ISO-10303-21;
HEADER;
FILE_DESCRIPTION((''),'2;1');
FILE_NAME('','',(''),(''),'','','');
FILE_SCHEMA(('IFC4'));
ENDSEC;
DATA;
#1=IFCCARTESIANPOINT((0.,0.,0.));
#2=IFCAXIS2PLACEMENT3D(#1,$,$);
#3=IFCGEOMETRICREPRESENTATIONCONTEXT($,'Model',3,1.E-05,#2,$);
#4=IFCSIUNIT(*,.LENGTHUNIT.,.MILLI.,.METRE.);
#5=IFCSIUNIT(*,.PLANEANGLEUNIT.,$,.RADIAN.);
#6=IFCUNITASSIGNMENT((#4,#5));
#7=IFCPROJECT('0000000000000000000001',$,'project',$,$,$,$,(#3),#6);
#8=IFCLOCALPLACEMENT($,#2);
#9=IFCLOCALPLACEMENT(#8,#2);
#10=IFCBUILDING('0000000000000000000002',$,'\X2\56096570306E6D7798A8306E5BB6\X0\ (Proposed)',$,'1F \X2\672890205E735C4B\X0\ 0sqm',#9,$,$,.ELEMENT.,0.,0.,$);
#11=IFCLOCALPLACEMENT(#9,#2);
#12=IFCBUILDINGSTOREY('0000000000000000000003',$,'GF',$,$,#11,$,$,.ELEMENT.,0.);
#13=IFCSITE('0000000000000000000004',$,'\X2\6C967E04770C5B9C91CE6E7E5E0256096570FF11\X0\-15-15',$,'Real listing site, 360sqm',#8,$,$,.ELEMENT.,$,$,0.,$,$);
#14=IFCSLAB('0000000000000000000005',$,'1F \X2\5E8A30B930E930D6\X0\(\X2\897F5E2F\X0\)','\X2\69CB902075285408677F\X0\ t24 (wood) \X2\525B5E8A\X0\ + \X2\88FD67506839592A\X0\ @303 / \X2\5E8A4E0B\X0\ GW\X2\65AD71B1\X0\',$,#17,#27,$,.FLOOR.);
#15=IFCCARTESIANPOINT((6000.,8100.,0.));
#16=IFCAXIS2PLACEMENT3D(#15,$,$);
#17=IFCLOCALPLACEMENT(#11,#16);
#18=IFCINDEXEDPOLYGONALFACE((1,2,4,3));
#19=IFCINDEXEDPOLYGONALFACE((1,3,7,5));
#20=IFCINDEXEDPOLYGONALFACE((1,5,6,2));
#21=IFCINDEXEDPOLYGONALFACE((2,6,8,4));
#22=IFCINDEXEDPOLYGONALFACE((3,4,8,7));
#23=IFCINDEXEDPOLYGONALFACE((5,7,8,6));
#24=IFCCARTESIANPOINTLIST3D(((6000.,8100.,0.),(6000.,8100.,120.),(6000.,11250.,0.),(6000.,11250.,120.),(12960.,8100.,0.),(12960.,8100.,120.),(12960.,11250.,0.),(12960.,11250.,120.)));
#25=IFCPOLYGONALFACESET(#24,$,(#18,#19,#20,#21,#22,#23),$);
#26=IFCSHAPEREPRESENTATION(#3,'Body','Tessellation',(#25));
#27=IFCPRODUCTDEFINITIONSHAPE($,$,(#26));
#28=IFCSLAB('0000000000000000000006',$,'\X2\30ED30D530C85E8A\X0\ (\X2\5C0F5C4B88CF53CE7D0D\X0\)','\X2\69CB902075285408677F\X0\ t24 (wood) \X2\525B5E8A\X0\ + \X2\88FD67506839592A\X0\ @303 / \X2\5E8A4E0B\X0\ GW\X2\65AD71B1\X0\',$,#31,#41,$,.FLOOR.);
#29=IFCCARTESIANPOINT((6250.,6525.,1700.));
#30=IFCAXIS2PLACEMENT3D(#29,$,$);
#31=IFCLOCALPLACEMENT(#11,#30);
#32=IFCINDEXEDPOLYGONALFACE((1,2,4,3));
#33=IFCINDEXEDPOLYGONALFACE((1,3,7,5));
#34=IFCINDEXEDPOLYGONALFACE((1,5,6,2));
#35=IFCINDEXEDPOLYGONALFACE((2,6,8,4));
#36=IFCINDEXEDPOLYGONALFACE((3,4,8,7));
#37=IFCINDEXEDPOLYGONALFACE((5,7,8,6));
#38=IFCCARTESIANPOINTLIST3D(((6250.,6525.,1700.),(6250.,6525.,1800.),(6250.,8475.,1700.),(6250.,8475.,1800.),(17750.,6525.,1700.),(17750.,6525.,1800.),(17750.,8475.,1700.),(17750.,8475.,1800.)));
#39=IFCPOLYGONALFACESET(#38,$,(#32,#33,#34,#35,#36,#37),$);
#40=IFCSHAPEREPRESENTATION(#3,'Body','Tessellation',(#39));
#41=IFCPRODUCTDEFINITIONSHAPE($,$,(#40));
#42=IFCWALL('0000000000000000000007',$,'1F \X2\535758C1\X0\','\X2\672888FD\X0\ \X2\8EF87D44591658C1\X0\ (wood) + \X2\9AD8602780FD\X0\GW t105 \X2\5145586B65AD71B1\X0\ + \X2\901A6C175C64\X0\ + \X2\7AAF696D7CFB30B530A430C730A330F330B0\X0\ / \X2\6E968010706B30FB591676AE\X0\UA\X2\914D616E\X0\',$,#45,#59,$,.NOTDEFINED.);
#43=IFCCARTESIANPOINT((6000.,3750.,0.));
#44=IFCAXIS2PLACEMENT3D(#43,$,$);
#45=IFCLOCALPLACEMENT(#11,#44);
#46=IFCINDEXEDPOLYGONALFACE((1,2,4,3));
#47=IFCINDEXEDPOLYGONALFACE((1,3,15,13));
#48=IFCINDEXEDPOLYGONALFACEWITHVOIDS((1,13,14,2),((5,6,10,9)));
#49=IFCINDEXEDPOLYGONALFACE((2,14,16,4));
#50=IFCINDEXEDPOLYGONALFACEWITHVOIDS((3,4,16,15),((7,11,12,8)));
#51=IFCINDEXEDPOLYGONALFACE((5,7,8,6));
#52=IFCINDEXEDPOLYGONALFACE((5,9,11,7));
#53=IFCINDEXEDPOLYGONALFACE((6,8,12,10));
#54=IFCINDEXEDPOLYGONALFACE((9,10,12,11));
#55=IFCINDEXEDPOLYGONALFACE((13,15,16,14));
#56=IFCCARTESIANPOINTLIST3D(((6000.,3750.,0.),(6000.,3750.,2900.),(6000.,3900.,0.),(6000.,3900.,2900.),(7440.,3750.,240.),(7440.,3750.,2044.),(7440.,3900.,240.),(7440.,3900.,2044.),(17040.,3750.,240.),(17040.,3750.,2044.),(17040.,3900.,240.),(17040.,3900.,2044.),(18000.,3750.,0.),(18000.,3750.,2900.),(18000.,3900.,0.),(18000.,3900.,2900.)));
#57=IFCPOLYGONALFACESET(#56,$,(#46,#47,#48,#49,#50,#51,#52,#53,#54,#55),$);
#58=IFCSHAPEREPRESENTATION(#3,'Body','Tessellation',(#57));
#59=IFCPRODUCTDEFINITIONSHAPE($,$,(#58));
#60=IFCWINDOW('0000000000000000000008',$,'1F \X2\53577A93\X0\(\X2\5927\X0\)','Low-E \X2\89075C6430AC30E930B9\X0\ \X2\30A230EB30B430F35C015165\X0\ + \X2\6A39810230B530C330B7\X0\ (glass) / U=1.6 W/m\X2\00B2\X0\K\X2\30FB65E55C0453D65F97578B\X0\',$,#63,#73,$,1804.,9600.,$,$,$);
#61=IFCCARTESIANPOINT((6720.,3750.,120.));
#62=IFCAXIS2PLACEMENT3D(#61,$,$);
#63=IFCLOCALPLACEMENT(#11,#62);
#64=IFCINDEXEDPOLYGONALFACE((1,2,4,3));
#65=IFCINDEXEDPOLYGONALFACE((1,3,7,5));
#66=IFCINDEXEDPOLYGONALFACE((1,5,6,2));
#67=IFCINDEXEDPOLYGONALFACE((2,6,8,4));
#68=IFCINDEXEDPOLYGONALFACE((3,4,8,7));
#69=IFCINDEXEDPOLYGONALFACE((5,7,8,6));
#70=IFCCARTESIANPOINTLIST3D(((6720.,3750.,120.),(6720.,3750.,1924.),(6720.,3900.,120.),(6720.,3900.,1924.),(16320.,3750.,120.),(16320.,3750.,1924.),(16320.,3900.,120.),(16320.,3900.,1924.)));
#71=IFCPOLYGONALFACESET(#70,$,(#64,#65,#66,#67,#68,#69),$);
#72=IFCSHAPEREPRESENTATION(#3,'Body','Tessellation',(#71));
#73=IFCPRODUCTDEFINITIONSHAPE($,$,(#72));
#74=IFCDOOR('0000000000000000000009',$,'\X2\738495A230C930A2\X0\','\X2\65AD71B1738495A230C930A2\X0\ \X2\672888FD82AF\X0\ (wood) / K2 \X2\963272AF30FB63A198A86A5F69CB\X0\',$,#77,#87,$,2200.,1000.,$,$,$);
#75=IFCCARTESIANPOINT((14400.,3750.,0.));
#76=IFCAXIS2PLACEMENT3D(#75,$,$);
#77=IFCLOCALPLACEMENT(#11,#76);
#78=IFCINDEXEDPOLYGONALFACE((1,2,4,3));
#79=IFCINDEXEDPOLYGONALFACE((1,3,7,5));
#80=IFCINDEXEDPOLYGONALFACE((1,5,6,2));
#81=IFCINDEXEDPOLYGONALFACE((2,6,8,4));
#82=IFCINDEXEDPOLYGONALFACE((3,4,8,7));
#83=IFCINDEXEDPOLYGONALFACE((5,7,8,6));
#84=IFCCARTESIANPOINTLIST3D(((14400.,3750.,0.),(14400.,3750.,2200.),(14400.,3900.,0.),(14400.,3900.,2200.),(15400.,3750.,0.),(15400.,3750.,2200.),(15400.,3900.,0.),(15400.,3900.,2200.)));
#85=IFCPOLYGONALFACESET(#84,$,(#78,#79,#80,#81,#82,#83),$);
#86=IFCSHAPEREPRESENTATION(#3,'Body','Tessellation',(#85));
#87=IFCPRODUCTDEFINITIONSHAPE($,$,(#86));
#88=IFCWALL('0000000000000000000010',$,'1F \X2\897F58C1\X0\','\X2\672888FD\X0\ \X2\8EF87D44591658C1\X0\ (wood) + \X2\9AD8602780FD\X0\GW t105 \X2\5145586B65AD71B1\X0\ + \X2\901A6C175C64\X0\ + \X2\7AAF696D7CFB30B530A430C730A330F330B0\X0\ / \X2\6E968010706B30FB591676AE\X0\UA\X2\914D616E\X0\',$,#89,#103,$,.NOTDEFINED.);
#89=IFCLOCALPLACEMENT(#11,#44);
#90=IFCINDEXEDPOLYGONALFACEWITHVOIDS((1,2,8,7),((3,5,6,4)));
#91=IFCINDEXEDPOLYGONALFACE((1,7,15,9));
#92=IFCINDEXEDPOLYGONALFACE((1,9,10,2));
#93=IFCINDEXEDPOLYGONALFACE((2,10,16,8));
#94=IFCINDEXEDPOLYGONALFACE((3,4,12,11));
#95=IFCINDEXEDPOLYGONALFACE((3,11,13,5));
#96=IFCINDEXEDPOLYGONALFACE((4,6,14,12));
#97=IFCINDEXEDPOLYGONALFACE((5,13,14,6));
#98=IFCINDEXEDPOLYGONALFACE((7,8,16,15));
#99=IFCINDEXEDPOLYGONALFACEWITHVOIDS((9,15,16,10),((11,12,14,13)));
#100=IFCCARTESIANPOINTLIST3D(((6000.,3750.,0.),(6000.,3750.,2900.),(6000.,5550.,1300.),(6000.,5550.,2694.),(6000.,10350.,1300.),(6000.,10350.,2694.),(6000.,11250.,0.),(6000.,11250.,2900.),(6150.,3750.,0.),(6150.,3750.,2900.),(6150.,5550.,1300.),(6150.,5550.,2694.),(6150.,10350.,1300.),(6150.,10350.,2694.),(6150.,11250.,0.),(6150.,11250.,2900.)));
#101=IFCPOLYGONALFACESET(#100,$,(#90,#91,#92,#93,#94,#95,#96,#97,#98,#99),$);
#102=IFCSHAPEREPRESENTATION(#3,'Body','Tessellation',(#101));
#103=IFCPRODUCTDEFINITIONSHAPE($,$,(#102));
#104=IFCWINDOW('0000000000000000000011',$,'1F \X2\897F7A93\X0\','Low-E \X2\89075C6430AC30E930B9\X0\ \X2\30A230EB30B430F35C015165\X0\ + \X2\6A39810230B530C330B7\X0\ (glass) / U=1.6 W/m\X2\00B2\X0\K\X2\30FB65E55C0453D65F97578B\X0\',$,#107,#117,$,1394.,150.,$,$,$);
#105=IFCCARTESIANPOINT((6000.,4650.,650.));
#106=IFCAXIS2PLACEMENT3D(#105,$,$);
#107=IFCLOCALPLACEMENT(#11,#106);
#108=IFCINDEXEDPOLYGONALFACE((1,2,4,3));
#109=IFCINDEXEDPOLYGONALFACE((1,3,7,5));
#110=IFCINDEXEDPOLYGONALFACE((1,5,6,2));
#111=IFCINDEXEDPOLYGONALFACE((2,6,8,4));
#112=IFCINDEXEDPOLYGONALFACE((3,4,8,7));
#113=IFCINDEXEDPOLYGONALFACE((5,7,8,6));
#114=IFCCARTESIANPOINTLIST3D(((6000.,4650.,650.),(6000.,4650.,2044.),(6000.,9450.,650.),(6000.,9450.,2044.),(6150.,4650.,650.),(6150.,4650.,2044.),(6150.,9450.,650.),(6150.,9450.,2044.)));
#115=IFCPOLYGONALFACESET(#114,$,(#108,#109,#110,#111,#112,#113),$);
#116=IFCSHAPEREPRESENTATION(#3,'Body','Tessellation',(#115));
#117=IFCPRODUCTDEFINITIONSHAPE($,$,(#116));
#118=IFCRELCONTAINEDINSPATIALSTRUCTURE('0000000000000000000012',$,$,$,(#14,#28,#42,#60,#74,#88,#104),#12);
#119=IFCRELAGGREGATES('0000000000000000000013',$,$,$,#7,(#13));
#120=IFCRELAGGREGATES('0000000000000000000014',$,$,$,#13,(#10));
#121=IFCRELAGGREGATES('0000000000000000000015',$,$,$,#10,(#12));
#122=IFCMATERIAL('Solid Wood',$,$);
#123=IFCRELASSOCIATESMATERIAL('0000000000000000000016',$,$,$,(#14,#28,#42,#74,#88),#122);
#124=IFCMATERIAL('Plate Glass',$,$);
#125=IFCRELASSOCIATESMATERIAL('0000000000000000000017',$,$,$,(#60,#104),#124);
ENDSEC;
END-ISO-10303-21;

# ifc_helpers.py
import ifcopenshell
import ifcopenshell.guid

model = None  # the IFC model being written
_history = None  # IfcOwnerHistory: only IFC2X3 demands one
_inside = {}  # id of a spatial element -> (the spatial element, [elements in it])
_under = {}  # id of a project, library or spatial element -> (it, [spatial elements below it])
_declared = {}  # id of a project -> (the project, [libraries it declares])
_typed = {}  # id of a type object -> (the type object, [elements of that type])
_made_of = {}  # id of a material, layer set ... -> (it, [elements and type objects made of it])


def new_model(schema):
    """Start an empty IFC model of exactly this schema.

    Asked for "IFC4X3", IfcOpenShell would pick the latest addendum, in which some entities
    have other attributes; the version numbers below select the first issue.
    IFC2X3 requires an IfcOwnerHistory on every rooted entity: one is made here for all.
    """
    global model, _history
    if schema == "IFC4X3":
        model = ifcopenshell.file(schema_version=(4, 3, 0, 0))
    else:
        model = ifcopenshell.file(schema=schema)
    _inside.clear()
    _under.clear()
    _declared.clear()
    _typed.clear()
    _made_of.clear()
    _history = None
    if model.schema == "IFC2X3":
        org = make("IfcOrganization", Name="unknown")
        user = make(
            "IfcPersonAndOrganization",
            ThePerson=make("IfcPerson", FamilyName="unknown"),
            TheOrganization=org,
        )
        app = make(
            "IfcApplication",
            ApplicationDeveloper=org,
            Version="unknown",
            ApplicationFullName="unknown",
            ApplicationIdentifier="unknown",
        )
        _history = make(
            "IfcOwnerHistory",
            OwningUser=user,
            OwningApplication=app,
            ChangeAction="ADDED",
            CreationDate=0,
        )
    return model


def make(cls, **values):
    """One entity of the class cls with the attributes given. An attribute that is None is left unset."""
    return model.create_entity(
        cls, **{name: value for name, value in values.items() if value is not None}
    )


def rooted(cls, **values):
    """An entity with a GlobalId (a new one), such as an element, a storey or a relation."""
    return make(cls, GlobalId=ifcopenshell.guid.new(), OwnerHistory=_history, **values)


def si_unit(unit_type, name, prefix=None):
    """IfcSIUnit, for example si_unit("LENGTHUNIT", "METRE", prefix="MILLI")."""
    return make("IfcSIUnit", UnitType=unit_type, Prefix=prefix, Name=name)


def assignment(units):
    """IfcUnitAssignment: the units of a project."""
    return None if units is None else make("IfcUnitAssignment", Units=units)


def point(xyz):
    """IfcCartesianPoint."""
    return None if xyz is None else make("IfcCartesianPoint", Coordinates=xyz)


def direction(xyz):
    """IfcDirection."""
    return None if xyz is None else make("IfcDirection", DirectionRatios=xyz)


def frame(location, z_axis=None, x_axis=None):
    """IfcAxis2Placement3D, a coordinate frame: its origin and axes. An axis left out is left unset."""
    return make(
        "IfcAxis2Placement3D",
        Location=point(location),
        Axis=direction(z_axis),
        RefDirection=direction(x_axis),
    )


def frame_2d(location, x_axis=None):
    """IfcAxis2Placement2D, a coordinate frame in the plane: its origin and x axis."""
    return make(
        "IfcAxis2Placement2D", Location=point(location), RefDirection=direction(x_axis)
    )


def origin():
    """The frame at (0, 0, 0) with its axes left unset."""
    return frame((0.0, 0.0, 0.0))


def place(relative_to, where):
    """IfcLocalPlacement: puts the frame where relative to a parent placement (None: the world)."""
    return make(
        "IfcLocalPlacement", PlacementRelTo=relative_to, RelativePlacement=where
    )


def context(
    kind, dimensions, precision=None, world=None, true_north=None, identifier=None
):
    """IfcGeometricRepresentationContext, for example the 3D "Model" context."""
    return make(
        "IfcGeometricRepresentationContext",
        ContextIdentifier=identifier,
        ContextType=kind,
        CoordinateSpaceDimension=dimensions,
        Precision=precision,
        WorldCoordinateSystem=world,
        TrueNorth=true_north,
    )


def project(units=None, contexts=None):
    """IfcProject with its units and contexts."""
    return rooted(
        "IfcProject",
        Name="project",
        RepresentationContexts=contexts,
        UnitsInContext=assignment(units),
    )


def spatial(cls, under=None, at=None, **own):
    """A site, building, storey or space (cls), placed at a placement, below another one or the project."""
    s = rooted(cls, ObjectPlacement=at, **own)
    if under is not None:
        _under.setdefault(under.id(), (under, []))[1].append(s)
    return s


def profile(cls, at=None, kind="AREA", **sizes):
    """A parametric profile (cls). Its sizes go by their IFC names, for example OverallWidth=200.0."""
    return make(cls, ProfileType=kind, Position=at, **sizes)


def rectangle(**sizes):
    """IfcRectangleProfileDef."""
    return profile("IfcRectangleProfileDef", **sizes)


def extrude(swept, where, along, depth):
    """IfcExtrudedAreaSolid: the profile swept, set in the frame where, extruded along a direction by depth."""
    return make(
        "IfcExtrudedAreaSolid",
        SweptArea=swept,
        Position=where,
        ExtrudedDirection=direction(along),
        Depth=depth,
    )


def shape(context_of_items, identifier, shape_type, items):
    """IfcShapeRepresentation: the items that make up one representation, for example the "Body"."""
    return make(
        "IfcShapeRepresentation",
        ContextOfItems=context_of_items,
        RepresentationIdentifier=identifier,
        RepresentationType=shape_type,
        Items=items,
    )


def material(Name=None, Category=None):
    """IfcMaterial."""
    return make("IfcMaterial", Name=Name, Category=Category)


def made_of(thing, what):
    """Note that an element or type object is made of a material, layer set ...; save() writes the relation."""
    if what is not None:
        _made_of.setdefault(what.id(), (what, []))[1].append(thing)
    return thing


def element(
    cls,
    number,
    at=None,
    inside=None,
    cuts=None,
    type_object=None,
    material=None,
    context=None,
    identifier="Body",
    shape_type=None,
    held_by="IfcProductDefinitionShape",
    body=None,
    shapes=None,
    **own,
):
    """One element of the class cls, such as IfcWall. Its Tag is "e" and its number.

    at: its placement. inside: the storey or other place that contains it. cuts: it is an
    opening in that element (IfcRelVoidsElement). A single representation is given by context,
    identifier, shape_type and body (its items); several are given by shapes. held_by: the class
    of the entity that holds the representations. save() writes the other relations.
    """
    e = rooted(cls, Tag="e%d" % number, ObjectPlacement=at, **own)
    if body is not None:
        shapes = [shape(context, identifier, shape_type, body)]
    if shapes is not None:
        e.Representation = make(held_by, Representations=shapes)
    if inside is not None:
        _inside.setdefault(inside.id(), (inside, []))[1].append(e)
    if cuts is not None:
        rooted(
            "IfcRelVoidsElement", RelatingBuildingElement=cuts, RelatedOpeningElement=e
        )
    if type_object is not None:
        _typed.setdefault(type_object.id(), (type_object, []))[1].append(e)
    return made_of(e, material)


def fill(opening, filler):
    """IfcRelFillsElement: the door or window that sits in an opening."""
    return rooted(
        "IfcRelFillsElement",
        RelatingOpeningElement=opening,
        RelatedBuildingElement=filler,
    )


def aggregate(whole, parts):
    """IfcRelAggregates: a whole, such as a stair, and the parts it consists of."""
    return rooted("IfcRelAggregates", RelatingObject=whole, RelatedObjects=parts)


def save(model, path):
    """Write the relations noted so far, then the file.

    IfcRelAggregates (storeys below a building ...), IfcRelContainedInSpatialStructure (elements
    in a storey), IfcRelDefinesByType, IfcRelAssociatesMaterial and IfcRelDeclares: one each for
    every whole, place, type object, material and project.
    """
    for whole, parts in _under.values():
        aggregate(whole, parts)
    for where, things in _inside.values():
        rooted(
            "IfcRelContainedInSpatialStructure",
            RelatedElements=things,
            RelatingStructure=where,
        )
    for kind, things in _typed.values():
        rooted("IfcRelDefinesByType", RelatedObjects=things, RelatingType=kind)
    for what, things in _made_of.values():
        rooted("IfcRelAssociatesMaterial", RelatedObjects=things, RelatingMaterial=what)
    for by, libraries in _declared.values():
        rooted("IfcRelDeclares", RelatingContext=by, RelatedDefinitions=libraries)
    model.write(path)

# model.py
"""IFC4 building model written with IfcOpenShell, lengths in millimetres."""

from ifc_helpers import new_model, si_unit, frame, frame_2d, origin, place, context, project, spatial, rectangle, extrude, material, element, fill, save


model = new_model("IFC4")

# Units and contexts
model_context = context("Model", 3, precision=1e-05, world=origin())
ifc_project = project(units=[si_unit("LENGTHUNIT", "METRE", prefix="MILLI"), si_unit("PLANEANGLEUNIT", "RADIAN")], contexts=[model_context])

# Site, building, storey
site_placement = place(None, origin())
site = spatial("IfcSite", under=ifc_project, at=site_placement, Name="沖縄県宜野湾市嘉数１-15-15", ObjectType="Real listing site, 360sqm", CompositionType="ELEMENT", RefElevation=0.0)
building_placement = place(site_placement, origin())
building = spatial("IfcBuilding", under=site, at=building_placement, Name="嘉数の海風の家 (Proposed)", ObjectType="1F 木造平屋 0sqm", CompositionType="ELEMENT", ElevationOfRefHeight=0.0, ElevationOfTerrain=0.0)
storey_placement = place(building_placement, origin())
storey = spatial("IfcBuildingStorey", under=building, at=storey_placement, Name="GF", CompositionType="ELEMENT", Elevation=0.0)

# Slabs
ifc_material_1 = material(Name="Solid Wood")
slab_1_placement = place(storey_placement, frame((6000.0, 8100.0, 0.0)))
element("IfcSlab", 1, at=slab_1_placement, inside=storey, material=ifc_material_1, Name="1F 床スラブ(西帯)", Description="構造用合板 t24 (wood) 剛床 + 製材根太 @303 / 床下 GW断熱", PredefinedType="FLOOR", context=model_context, shape_type="SweptSolid", body=[
    extrude(rectangle(XDim=6960.0, YDim=3150.0, at=frame_2d((3480.0, 1575.0))), frame((6000.0, 8100.0, 0.0)), (0.0, 0.0, 1.0), 120.0),
])
slab_2_placement = place(storey_placement, frame((6250.0, 6525.0, 1700.0)))
element("IfcSlab", 2, at=slab_2_placement, inside=storey, material=ifc_material_1, Name="ロフト床 (小屋裏収納)", Description="構造用合板 t24 (wood) 剛床 + 製材根太 @303 / 床下 GW断熱", PredefinedType="FLOOR", context=model_context, shape_type="SweptSolid", body=[
    extrude(rectangle(XDim=11500.0, YDim=1950.0, at=frame_2d((5750.0, 975.0))), frame((6250.0, 6525.0, 1700.0)), (0.0, 0.0, 1.0), 100.0),
])

# Wall, openings, window, door
wall_1_placement = place(storey_placement, frame((6000.0, 3750.0, 0.0)))
wall_1 = element("IfcWall", 3, at=wall_1_placement, inside=storey, material=ifc_material_1, Name="1F 南壁", Description="木製 軸組外壁 (wood) + 高性能GW t105 充填断熱 + 通気層 + 窯業系サイディング / 準耐火・外皮UA配慮", PredefinedType="NOTDEFINED", context=model_context, shape_type="SweptSolid", body=[
    extrude(rectangle(XDim=12000.0, YDim=150.0, at=frame_2d((6000.0, 75.0))), frame((6000.0, 3750.0, 0.0)), (0.0, 0.0, 1.0), 2900.0),
])
opening_1_placement = place(storey_placement, frame((6720.0, 3750.0, 120.0)))
opening_1 = element("IfcOpeningElement", 4, at=opening_1_placement, cuts=wall_1, PredefinedType="NOTDEFINED", context=model_context, shape_type="SweptSolid", body=[
    extrude(rectangle(XDim=9600.0, YDim=150.0, at=frame_2d((4800.0, 75.0))), frame((6720.0, 3750.0, 120.0)), (0.0, 0.0, 1.0), 1804.0),
])
opening_2_placement = place(storey_placement, frame((14400.0, 3750.0, 0.0)))
opening_2 = element("IfcOpeningElement", 5, at=opening_2_placement, cuts=wall_1, PredefinedType="NOTDEFINED", context=model_context, shape_type="SweptSolid", body=[
    extrude(rectangle(XDim=1000.0, YDim=150.0, at=frame_2d((500.0, 75.0))), frame((14400.0, 3750.0, 0.0)), (0.0, 0.0, 1.0), 2200.0),
])
ifc_material_2 = material(Name="Plate Glass")
window_1_placement = place(storey_placement, frame((6720.0, 3750.0, 120.0)))
window_1 = element("IfcWindow", 6, at=window_1_placement, inside=storey, material=ifc_material_2, Name="1F 南窓(大)", Description="Low-E 複層ガラス アルゴン封入 + 樹脂サッシ (glass) / U=1.6 W/m²K・日射取得型", OverallHeight=1804.0, OverallWidth=9600.0, context=model_context, shape_type="SweptSolid", body=[
    extrude(rectangle(XDim=9600.0, YDim=150.0, at=frame_2d((4800.0, 75.0))), frame((6720.0, 3750.0, 120.0)), (0.0, 0.0, 1.0), 1804.0),
])
fill(opening_1, window_1)
door_1_placement = place(storey_placement, frame((14400.0, 3750.0, 0.0)))
door_1 = element("IfcDoor", 7, at=door_1_placement, inside=storey, material=ifc_material_1, Name="玄関ドア", Description="断熱玄関ドア 木製芯 (wood) / K2 防犯・採風機構", OverallHeight=2200.0, OverallWidth=1000.0, context=model_context, shape_type="SweptSolid", body=[
    extrude(rectangle(XDim=1000.0, YDim=150.0, at=frame_2d((500.0, 75.0))), frame((14400.0, 3750.0, 0.0)), (0.0, 0.0, 1.0), 2200.0),
])
fill(opening_2, door_1)

# Wall, opening, window
wall_2_placement = place(storey_placement, frame((6000.0, 3750.0, 0.0)))
wall_2 = element("IfcWall", 8, at=wall_2_placement, inside=storey, material=ifc_material_1, Name="1F 西壁", Description="木製 軸組外壁 (wood) + 高性能GW t105 充填断熱 + 通気層 + 窯業系サイディング / 準耐火・外皮UA配慮", PredefinedType="NOTDEFINED", context=model_context, shape_type="SweptSolid", body=[
    extrude(rectangle(XDim=150.0, YDim=7500.0, at=frame_2d((75.0, 3750.0))), frame((6000.0, 3750.0, 0.0)), (0.0, 0.0, 1.0), 2900.0),
])
opening_3_placement = place(storey_placement, frame((6000.0, 4650.0, 650.0)))
opening_3 = element("IfcOpeningElement", 9, at=opening_3_placement, cuts=wall_2, PredefinedType="NOTDEFINED", context=model_context, shape_type="SweptSolid", body=[
    extrude(rectangle(XDim=150.0, YDim=4800.0, at=frame_2d((75.0, 2400.0))), frame((6000.0, 4650.0, 650.0)), (0.0, 0.0, 1.0), 1394.0),
])
window_2_placement = place(storey_placement, frame((6000.0, 4650.0, 650.0)))
window_2 = element("IfcWindow", 10, at=window_2_placement, inside=storey, material=ifc_material_2, Name="1F 西窓", Description="Low-E 複層ガラス アルゴン封入 + 樹脂サッシ (glass) / U=1.6 W/m²K・日射取得型", OverallHeight=1394.0, OverallWidth=150.0, context=model_context, shape_type="SweptSolid", body=[
    extrude(rectangle(XDim=150.0, YDim=4800.0, at=frame_2d((75.0, 2400.0))), frame((6000.0, 4650.0, 650.0)), (0.0, 0.0, 1.0), 1394.0),
])
fill(opening_3, window_2)

save(model, "model.ifc")
